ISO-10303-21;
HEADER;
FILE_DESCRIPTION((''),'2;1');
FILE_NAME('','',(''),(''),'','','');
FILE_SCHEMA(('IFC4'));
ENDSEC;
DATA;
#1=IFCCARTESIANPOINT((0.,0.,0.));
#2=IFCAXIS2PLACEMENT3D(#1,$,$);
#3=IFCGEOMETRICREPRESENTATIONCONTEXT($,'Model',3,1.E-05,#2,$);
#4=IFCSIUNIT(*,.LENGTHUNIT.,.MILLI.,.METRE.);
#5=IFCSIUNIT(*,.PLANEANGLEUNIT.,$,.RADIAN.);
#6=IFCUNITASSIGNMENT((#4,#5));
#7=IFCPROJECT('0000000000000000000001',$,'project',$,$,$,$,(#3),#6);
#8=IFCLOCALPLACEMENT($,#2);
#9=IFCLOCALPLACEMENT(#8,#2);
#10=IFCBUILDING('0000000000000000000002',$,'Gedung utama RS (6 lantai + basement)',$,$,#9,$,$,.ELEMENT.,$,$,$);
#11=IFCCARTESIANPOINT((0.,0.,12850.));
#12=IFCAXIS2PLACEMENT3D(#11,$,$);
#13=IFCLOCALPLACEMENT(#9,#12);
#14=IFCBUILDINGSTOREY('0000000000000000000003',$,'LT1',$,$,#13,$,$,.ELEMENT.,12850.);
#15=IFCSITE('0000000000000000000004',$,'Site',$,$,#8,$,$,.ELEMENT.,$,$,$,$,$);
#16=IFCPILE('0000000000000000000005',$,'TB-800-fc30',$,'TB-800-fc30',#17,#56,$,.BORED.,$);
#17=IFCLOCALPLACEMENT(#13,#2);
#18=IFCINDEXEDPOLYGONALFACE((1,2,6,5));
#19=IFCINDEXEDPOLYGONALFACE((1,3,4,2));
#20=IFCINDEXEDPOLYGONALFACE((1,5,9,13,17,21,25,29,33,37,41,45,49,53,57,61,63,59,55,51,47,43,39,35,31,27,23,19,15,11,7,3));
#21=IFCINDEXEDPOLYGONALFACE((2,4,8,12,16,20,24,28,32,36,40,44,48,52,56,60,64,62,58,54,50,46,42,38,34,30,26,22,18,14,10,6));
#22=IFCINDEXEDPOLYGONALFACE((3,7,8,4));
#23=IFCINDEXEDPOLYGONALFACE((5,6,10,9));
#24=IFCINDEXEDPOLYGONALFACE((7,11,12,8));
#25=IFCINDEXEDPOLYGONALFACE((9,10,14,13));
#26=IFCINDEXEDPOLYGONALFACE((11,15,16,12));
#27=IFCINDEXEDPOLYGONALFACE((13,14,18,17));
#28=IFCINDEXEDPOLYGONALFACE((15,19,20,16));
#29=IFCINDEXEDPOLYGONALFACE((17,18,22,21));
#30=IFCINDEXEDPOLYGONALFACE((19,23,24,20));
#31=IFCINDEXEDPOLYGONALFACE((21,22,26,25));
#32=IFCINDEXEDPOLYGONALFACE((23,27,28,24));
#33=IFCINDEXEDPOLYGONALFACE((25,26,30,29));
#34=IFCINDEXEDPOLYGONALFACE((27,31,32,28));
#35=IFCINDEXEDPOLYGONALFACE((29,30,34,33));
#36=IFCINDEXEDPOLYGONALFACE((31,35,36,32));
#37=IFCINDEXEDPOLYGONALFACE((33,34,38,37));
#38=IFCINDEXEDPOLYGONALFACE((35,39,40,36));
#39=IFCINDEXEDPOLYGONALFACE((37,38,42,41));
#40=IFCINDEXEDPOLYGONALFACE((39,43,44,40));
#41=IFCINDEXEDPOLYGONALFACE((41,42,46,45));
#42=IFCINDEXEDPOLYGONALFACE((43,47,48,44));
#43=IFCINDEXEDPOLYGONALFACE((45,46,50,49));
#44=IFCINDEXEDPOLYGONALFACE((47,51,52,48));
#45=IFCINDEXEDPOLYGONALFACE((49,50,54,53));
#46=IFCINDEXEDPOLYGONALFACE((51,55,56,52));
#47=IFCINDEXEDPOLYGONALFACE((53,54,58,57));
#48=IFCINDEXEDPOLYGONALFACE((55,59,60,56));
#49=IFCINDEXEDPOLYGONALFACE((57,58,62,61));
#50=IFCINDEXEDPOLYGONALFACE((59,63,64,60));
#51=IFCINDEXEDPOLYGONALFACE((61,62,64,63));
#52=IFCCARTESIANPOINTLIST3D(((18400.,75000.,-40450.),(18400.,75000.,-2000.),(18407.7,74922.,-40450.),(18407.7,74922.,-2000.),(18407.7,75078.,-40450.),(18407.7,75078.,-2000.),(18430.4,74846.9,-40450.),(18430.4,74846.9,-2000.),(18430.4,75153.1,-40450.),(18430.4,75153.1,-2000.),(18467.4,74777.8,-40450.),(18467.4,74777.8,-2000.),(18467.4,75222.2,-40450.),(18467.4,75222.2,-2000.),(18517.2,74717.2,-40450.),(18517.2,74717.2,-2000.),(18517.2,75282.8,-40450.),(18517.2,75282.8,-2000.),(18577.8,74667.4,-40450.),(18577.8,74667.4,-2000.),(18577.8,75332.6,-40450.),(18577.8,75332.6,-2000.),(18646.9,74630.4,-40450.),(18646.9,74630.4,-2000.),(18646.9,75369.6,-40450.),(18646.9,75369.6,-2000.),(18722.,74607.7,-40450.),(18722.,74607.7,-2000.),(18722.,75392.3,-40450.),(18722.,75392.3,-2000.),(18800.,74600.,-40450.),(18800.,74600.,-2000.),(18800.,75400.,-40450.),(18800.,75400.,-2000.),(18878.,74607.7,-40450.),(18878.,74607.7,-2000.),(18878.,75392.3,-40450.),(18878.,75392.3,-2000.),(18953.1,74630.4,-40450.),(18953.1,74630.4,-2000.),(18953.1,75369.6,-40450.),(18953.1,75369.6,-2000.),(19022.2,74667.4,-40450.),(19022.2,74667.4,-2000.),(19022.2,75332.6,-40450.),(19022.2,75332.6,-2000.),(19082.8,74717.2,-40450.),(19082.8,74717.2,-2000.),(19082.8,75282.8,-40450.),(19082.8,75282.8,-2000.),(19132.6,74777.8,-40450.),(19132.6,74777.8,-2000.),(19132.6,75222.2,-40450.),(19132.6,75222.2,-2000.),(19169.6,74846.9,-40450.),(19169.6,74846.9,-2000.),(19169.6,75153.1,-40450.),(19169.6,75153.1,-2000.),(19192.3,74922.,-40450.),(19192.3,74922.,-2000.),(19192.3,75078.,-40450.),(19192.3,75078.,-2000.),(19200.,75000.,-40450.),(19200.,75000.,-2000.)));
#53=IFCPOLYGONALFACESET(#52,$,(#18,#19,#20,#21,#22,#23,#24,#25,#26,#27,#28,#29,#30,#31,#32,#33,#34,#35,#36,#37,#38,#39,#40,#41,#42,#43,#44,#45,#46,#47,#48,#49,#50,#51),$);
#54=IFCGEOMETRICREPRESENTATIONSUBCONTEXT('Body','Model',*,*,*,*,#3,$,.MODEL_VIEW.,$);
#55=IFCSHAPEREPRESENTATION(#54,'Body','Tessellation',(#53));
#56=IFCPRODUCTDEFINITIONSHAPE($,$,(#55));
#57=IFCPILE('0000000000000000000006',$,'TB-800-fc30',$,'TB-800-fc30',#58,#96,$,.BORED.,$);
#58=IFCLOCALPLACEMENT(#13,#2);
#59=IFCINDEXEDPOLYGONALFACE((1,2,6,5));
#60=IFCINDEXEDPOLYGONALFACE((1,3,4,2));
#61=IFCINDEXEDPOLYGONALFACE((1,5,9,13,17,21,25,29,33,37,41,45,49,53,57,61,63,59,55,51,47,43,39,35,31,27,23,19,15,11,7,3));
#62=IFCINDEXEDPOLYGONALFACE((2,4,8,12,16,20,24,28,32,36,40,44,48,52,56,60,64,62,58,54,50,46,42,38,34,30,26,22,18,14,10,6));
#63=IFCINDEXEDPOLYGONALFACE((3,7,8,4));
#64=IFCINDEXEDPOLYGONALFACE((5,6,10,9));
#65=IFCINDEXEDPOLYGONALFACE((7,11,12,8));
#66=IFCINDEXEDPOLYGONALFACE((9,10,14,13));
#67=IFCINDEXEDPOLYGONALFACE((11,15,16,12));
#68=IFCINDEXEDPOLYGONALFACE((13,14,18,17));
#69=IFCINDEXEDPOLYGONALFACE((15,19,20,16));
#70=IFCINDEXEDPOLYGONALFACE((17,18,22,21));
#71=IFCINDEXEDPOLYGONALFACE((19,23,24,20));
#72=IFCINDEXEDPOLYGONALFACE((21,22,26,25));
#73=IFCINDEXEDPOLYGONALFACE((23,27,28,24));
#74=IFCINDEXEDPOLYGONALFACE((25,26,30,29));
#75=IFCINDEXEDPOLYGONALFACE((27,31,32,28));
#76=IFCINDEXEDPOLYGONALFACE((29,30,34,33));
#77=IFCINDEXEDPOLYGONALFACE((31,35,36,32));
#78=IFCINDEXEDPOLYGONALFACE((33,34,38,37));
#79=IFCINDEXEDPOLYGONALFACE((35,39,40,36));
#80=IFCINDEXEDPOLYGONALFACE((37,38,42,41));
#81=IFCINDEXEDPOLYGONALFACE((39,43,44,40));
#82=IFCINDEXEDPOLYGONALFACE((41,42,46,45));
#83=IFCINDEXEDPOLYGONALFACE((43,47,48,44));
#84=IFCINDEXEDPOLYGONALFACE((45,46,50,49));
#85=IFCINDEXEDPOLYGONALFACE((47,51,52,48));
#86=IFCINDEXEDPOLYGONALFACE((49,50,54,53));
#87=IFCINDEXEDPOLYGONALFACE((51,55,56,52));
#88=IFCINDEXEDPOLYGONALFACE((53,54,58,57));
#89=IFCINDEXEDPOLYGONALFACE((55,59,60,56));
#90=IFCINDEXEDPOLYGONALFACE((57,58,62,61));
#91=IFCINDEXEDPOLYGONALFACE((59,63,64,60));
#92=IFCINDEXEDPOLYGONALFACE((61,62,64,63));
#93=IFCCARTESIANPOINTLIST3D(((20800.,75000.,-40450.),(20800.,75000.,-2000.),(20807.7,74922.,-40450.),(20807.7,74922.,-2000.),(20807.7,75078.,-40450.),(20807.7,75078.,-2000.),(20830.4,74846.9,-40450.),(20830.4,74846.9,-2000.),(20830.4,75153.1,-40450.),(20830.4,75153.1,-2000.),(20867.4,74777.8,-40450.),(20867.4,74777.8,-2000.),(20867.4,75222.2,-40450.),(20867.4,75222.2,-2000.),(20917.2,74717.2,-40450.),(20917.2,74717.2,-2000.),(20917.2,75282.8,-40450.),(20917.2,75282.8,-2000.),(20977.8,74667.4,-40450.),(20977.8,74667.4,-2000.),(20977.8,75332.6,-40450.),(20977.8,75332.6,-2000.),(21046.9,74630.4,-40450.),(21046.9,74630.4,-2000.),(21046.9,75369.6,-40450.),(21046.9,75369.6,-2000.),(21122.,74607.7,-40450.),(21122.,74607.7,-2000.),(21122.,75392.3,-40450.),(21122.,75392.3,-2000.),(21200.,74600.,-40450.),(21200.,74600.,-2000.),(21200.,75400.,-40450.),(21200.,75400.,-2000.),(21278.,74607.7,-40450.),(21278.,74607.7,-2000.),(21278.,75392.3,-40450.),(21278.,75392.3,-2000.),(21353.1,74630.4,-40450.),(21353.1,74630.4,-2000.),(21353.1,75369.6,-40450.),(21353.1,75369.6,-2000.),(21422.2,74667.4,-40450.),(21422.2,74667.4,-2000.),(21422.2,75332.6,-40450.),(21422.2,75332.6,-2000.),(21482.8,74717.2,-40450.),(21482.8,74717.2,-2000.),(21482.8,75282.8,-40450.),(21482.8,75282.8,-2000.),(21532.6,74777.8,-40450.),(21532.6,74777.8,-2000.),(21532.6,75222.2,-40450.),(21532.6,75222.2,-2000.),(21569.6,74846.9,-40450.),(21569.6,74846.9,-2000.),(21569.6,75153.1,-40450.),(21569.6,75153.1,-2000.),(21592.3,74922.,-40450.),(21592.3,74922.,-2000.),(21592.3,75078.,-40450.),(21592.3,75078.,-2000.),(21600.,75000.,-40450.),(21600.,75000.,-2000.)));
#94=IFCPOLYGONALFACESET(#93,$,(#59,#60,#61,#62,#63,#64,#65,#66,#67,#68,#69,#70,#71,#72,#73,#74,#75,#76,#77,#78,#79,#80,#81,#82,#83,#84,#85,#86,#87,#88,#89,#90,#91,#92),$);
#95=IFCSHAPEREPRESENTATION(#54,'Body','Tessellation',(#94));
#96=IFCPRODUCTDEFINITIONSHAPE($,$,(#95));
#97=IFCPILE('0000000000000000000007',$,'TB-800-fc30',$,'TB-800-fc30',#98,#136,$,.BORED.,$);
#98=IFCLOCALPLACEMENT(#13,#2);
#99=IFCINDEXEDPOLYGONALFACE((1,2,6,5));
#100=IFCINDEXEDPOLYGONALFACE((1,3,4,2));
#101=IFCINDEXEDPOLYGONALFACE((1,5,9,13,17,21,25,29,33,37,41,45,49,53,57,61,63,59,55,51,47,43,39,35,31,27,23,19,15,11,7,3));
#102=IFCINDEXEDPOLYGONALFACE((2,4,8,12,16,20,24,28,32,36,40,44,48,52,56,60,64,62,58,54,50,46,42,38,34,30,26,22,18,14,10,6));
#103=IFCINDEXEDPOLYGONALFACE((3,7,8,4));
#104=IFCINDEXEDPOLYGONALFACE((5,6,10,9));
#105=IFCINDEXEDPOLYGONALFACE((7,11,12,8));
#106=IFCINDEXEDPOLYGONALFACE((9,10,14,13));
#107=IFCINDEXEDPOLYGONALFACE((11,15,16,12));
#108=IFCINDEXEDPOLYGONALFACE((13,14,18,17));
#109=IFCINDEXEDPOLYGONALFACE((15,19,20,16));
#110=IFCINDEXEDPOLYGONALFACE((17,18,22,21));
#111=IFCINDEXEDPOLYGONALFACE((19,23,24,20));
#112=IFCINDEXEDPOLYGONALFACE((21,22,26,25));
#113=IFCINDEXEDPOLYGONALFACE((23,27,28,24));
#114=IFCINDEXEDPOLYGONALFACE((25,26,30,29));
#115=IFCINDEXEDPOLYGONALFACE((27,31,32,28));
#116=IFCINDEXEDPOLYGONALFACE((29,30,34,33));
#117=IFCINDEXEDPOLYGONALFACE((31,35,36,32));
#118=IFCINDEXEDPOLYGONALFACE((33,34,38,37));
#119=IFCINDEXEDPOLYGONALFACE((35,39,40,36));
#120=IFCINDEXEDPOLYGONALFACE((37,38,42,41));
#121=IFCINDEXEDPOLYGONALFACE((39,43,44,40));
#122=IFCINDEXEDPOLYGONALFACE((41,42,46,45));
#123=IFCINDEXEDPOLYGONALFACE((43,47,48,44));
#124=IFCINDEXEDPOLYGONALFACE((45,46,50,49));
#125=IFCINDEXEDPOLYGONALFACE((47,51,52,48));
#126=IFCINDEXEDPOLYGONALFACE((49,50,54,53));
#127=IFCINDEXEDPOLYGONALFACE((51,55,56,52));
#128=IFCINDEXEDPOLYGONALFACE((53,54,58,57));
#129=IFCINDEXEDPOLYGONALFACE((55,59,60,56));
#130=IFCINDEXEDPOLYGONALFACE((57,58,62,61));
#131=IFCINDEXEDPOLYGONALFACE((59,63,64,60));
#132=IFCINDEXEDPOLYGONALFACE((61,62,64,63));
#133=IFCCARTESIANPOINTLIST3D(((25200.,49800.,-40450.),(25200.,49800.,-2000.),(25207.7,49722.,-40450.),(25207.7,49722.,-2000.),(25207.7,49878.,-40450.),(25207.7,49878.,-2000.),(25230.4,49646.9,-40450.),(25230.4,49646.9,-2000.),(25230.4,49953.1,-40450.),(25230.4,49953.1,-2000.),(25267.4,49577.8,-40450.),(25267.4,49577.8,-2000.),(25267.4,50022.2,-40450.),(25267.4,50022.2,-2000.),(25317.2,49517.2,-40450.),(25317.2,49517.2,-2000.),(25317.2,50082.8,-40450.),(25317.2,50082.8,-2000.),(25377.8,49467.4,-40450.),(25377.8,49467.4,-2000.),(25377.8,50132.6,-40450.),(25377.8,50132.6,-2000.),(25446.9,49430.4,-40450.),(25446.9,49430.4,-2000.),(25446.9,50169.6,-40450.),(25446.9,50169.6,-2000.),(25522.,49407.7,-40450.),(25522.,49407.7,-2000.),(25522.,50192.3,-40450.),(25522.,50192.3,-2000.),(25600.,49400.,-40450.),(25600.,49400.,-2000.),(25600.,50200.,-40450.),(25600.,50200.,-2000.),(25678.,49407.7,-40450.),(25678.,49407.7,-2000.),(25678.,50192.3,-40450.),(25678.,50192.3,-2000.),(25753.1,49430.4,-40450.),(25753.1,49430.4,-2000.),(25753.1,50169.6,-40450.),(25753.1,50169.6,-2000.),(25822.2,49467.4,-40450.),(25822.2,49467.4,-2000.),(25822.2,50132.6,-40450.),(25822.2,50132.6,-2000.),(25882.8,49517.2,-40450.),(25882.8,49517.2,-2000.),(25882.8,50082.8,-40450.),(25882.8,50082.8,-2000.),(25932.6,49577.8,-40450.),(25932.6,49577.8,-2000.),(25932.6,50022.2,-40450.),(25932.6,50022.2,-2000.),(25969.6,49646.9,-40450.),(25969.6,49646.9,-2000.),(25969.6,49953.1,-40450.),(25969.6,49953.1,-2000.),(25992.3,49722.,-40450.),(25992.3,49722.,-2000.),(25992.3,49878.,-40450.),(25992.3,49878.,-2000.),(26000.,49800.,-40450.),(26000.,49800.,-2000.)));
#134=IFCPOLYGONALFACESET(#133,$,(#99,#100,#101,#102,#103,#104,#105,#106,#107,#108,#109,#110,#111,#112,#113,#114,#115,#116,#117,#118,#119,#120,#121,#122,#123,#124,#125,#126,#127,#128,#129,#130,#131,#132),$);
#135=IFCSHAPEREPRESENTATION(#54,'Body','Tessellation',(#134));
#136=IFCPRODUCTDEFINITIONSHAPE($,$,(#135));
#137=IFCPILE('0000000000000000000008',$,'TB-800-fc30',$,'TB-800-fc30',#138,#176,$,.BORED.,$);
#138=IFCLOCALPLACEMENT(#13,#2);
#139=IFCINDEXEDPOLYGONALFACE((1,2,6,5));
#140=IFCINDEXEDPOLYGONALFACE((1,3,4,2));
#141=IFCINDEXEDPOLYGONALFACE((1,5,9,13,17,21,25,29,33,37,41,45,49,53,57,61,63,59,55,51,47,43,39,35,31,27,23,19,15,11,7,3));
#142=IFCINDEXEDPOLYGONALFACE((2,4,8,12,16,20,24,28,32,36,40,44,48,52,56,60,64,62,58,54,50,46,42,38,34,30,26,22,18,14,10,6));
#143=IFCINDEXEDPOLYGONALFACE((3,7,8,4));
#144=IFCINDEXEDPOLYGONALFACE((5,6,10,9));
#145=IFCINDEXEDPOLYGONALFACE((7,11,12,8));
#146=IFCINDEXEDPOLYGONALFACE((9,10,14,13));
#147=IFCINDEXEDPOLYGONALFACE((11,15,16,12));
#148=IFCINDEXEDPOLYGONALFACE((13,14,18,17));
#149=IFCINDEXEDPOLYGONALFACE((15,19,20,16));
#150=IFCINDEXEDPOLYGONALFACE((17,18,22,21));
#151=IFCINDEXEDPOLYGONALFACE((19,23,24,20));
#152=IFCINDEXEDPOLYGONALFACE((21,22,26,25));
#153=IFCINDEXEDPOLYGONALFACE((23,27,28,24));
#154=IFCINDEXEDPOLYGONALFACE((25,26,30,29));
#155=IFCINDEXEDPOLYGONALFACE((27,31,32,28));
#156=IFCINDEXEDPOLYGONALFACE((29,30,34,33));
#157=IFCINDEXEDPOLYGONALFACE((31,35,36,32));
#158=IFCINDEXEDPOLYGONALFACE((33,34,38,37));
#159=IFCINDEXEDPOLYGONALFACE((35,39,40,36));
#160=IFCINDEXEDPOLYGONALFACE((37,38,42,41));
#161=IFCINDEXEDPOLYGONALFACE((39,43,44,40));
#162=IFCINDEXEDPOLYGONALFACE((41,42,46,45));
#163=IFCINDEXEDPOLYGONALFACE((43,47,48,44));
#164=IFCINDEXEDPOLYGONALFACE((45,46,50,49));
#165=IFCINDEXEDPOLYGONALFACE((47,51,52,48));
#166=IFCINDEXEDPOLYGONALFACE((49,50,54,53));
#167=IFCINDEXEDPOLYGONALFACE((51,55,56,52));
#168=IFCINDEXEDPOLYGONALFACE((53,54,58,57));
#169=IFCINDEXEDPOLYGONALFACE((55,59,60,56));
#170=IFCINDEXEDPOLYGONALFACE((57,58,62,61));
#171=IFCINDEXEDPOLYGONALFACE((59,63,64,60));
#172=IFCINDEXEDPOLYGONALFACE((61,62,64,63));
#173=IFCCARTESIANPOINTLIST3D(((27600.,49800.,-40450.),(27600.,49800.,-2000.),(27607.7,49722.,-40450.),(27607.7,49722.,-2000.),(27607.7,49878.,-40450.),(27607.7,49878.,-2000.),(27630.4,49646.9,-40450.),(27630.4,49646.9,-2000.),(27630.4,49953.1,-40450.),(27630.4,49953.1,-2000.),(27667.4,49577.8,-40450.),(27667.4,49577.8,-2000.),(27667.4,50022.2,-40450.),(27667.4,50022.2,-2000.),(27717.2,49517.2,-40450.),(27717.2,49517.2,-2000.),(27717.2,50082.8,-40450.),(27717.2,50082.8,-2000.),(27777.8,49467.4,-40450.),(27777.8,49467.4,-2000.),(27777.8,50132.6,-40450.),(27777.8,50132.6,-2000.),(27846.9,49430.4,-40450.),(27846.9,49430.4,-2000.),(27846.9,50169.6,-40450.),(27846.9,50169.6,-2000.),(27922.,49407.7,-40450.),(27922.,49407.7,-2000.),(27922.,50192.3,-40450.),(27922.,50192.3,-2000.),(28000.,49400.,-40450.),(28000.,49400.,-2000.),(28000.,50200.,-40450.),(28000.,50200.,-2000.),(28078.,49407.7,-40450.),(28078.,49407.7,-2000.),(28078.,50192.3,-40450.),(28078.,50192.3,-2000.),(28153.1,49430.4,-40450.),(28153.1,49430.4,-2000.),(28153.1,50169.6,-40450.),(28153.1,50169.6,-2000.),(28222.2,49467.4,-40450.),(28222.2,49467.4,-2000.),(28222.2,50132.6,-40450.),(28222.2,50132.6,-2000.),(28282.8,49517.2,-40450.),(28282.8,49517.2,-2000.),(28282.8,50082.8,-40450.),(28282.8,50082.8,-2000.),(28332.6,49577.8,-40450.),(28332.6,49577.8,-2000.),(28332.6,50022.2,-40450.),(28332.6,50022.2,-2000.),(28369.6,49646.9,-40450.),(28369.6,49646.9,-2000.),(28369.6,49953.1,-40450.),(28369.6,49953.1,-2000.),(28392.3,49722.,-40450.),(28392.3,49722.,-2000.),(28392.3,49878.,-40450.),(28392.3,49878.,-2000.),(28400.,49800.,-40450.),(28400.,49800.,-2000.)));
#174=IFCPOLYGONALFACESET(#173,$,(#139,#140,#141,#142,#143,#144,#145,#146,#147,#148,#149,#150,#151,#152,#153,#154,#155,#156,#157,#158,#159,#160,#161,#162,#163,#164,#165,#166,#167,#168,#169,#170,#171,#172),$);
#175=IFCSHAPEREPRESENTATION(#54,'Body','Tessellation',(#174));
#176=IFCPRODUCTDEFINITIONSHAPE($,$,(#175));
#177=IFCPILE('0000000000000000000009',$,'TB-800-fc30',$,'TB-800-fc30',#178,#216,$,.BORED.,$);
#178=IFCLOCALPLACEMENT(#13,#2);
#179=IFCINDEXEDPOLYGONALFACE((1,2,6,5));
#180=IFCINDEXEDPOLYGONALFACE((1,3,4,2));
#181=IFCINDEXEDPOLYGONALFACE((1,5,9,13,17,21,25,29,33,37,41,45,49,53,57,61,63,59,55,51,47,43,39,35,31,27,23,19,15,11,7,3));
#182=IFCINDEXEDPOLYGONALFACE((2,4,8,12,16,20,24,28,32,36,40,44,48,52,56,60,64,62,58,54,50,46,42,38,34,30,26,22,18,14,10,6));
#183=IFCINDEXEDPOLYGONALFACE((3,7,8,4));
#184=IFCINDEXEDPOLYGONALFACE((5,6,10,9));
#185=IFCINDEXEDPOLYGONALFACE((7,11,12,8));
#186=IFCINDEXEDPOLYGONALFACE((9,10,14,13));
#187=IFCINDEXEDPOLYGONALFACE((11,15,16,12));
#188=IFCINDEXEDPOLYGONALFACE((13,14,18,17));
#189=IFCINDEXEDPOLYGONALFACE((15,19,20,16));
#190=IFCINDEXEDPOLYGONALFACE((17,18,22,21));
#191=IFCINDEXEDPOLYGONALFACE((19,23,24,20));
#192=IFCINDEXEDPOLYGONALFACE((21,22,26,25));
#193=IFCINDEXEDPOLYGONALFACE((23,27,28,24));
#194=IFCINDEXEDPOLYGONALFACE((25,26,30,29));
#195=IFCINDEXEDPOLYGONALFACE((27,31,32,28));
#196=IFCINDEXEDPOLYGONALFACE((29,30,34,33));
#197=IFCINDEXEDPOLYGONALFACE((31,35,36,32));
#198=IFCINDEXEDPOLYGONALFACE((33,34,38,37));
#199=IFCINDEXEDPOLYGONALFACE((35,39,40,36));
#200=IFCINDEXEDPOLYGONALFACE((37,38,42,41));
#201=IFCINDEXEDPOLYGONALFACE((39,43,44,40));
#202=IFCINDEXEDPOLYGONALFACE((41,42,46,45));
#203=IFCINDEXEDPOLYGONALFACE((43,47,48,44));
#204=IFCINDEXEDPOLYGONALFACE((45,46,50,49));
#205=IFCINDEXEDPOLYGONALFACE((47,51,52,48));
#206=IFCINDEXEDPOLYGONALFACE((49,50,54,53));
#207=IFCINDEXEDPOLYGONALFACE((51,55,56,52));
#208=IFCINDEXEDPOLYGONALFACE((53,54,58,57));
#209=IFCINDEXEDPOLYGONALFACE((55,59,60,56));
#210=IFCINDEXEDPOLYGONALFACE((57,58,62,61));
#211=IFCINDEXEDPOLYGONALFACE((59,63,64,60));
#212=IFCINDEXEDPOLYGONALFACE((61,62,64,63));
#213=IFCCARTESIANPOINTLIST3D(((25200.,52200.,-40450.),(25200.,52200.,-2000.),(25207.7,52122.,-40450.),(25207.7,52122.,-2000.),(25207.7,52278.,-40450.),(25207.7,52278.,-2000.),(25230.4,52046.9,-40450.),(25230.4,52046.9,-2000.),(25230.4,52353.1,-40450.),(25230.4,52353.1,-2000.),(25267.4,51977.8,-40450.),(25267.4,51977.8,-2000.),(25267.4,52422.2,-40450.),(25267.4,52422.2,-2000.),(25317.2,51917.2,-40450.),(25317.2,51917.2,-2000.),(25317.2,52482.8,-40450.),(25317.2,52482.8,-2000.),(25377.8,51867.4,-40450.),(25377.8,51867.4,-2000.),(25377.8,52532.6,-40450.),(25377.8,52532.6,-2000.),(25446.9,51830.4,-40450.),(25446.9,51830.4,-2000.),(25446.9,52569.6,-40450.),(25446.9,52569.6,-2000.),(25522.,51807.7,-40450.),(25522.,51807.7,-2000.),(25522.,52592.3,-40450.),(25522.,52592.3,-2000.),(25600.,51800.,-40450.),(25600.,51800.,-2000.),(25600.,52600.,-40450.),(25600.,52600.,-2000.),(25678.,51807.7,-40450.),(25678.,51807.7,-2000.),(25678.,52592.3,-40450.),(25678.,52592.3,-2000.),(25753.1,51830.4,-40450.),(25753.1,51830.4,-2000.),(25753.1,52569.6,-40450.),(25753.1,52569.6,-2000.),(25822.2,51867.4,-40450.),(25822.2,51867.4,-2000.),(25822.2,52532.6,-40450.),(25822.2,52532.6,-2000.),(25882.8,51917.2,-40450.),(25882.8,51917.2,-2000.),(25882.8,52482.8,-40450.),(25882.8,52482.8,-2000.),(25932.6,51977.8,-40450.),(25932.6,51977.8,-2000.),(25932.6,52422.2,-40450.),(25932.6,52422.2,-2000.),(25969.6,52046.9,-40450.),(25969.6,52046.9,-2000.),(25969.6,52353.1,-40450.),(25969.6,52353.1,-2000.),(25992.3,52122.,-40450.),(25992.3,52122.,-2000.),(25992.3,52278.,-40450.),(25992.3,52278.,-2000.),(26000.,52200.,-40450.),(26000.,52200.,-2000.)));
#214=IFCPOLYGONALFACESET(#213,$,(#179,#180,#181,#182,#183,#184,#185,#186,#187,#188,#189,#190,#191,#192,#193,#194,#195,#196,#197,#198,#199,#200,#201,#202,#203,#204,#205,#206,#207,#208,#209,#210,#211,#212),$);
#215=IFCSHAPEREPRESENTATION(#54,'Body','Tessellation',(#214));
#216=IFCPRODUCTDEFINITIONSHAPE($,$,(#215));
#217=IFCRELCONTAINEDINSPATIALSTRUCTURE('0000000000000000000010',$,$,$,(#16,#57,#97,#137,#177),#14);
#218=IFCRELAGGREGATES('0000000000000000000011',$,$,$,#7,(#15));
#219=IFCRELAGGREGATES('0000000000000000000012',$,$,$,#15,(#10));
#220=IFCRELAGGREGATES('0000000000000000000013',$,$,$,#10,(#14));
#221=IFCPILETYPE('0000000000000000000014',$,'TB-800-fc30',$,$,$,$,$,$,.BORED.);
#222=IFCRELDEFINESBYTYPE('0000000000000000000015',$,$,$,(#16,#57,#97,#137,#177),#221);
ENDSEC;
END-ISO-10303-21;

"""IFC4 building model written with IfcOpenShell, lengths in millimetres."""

from ifc_helpers import new_model, si_unit, frame, origin, origin_2d, place, context, subcontext, project, spatial, circle, extrude, material_profile, profile_set, profile_usage, type_object, element, save


model = new_model("IFC4")

# Units and contexts
model_context = context("Model", 3, precision=1e-05, world=origin())
body_context = subcontext(model_context, "Body", "Model", "MODEL_VIEW")
ifc_project = project(units=[si_unit("LENGTHUNIT", "METRE", prefix="MILLI"), si_unit("PLANEANGLEUNIT", "RADIAN")], contexts=[model_context])

# Site, building, storey
site_placement = place(None, origin())
site = spatial("IfcSite", under=ifc_project, at=site_placement, Name="Site", CompositionType="ELEMENT")
building_placement = place(site_placement, origin())
building = spatial("IfcBuilding", under=site, at=building_placement, Name="Gedung utama RS (6 lantai + basement)", CompositionType="ELEMENT")
storey_placement = place(building_placement, frame((0.0, 0.0, 12850.0)))
storey = spatial("IfcBuildingStorey", under=building, at=storey_placement, Name="LT1", CompositionType="ELEMENT", Elevation=12850.0)

# Piles
ifc_material_profile = material_profile(None, circle(Radius=400.0, at=origin_2d()), Name="TB-800-fc30")
ifc_profile_set = profile_set([ifc_material_profile], Name="TB-800-fc30")
ifc_profile_usage = profile_usage(ifc_profile_set, cardinal=5)
pile_type = type_object("IfcPileType", Name="TB-800-fc30", PredefinedType="BORED", material=ifc_profile_set)
for number, where, z_axis, x_axis, name in (
    (1, (18800.0, 75000.0, -40450.0), (0.0, 0.0, 1.0), (1.0, 0.0, 0.0), "TB-800-fc30"),
    (2, (21200.0, 75000.0, -40450.0), (0.0, 0.0, 1.0), (1.0, 0.0, 0.0), "TB-800-fc30"),
    (3, (25600.0, 49800.0, -40450.0), (0.0, 0.0, 1.0), (1.0, 0.0, 0.0), "TB-800-fc30"),
    (4, (28000.0, 49800.0, -40450.0), (0.0, 0.0, 1.0), (1.0, 0.0, 0.0), "TB-800-fc30"),
    (5, (25600.0, 52200.0, -40450.0), (0.0, 0.0, 1.0), (1.0, 0.0, 0.0), "TB-800-fc30"),
):
    element("IfcPile", number, at=place(storey_placement, frame(where, z_axis=z_axis, x_axis=x_axis)), inside=storey, type_object=pile_type, material=ifc_profile_usage, Name=name, ObjectType="TB-800-fc30", PredefinedType="BORED", context=body_context, shape_type="SweptSolid", body=[
        extrude(circle(Radius=400.0, at=origin_2d()), origin(), (0.0, 0.0, 1.0), 38450.0),
    ])

save(model, "model.ifc")
